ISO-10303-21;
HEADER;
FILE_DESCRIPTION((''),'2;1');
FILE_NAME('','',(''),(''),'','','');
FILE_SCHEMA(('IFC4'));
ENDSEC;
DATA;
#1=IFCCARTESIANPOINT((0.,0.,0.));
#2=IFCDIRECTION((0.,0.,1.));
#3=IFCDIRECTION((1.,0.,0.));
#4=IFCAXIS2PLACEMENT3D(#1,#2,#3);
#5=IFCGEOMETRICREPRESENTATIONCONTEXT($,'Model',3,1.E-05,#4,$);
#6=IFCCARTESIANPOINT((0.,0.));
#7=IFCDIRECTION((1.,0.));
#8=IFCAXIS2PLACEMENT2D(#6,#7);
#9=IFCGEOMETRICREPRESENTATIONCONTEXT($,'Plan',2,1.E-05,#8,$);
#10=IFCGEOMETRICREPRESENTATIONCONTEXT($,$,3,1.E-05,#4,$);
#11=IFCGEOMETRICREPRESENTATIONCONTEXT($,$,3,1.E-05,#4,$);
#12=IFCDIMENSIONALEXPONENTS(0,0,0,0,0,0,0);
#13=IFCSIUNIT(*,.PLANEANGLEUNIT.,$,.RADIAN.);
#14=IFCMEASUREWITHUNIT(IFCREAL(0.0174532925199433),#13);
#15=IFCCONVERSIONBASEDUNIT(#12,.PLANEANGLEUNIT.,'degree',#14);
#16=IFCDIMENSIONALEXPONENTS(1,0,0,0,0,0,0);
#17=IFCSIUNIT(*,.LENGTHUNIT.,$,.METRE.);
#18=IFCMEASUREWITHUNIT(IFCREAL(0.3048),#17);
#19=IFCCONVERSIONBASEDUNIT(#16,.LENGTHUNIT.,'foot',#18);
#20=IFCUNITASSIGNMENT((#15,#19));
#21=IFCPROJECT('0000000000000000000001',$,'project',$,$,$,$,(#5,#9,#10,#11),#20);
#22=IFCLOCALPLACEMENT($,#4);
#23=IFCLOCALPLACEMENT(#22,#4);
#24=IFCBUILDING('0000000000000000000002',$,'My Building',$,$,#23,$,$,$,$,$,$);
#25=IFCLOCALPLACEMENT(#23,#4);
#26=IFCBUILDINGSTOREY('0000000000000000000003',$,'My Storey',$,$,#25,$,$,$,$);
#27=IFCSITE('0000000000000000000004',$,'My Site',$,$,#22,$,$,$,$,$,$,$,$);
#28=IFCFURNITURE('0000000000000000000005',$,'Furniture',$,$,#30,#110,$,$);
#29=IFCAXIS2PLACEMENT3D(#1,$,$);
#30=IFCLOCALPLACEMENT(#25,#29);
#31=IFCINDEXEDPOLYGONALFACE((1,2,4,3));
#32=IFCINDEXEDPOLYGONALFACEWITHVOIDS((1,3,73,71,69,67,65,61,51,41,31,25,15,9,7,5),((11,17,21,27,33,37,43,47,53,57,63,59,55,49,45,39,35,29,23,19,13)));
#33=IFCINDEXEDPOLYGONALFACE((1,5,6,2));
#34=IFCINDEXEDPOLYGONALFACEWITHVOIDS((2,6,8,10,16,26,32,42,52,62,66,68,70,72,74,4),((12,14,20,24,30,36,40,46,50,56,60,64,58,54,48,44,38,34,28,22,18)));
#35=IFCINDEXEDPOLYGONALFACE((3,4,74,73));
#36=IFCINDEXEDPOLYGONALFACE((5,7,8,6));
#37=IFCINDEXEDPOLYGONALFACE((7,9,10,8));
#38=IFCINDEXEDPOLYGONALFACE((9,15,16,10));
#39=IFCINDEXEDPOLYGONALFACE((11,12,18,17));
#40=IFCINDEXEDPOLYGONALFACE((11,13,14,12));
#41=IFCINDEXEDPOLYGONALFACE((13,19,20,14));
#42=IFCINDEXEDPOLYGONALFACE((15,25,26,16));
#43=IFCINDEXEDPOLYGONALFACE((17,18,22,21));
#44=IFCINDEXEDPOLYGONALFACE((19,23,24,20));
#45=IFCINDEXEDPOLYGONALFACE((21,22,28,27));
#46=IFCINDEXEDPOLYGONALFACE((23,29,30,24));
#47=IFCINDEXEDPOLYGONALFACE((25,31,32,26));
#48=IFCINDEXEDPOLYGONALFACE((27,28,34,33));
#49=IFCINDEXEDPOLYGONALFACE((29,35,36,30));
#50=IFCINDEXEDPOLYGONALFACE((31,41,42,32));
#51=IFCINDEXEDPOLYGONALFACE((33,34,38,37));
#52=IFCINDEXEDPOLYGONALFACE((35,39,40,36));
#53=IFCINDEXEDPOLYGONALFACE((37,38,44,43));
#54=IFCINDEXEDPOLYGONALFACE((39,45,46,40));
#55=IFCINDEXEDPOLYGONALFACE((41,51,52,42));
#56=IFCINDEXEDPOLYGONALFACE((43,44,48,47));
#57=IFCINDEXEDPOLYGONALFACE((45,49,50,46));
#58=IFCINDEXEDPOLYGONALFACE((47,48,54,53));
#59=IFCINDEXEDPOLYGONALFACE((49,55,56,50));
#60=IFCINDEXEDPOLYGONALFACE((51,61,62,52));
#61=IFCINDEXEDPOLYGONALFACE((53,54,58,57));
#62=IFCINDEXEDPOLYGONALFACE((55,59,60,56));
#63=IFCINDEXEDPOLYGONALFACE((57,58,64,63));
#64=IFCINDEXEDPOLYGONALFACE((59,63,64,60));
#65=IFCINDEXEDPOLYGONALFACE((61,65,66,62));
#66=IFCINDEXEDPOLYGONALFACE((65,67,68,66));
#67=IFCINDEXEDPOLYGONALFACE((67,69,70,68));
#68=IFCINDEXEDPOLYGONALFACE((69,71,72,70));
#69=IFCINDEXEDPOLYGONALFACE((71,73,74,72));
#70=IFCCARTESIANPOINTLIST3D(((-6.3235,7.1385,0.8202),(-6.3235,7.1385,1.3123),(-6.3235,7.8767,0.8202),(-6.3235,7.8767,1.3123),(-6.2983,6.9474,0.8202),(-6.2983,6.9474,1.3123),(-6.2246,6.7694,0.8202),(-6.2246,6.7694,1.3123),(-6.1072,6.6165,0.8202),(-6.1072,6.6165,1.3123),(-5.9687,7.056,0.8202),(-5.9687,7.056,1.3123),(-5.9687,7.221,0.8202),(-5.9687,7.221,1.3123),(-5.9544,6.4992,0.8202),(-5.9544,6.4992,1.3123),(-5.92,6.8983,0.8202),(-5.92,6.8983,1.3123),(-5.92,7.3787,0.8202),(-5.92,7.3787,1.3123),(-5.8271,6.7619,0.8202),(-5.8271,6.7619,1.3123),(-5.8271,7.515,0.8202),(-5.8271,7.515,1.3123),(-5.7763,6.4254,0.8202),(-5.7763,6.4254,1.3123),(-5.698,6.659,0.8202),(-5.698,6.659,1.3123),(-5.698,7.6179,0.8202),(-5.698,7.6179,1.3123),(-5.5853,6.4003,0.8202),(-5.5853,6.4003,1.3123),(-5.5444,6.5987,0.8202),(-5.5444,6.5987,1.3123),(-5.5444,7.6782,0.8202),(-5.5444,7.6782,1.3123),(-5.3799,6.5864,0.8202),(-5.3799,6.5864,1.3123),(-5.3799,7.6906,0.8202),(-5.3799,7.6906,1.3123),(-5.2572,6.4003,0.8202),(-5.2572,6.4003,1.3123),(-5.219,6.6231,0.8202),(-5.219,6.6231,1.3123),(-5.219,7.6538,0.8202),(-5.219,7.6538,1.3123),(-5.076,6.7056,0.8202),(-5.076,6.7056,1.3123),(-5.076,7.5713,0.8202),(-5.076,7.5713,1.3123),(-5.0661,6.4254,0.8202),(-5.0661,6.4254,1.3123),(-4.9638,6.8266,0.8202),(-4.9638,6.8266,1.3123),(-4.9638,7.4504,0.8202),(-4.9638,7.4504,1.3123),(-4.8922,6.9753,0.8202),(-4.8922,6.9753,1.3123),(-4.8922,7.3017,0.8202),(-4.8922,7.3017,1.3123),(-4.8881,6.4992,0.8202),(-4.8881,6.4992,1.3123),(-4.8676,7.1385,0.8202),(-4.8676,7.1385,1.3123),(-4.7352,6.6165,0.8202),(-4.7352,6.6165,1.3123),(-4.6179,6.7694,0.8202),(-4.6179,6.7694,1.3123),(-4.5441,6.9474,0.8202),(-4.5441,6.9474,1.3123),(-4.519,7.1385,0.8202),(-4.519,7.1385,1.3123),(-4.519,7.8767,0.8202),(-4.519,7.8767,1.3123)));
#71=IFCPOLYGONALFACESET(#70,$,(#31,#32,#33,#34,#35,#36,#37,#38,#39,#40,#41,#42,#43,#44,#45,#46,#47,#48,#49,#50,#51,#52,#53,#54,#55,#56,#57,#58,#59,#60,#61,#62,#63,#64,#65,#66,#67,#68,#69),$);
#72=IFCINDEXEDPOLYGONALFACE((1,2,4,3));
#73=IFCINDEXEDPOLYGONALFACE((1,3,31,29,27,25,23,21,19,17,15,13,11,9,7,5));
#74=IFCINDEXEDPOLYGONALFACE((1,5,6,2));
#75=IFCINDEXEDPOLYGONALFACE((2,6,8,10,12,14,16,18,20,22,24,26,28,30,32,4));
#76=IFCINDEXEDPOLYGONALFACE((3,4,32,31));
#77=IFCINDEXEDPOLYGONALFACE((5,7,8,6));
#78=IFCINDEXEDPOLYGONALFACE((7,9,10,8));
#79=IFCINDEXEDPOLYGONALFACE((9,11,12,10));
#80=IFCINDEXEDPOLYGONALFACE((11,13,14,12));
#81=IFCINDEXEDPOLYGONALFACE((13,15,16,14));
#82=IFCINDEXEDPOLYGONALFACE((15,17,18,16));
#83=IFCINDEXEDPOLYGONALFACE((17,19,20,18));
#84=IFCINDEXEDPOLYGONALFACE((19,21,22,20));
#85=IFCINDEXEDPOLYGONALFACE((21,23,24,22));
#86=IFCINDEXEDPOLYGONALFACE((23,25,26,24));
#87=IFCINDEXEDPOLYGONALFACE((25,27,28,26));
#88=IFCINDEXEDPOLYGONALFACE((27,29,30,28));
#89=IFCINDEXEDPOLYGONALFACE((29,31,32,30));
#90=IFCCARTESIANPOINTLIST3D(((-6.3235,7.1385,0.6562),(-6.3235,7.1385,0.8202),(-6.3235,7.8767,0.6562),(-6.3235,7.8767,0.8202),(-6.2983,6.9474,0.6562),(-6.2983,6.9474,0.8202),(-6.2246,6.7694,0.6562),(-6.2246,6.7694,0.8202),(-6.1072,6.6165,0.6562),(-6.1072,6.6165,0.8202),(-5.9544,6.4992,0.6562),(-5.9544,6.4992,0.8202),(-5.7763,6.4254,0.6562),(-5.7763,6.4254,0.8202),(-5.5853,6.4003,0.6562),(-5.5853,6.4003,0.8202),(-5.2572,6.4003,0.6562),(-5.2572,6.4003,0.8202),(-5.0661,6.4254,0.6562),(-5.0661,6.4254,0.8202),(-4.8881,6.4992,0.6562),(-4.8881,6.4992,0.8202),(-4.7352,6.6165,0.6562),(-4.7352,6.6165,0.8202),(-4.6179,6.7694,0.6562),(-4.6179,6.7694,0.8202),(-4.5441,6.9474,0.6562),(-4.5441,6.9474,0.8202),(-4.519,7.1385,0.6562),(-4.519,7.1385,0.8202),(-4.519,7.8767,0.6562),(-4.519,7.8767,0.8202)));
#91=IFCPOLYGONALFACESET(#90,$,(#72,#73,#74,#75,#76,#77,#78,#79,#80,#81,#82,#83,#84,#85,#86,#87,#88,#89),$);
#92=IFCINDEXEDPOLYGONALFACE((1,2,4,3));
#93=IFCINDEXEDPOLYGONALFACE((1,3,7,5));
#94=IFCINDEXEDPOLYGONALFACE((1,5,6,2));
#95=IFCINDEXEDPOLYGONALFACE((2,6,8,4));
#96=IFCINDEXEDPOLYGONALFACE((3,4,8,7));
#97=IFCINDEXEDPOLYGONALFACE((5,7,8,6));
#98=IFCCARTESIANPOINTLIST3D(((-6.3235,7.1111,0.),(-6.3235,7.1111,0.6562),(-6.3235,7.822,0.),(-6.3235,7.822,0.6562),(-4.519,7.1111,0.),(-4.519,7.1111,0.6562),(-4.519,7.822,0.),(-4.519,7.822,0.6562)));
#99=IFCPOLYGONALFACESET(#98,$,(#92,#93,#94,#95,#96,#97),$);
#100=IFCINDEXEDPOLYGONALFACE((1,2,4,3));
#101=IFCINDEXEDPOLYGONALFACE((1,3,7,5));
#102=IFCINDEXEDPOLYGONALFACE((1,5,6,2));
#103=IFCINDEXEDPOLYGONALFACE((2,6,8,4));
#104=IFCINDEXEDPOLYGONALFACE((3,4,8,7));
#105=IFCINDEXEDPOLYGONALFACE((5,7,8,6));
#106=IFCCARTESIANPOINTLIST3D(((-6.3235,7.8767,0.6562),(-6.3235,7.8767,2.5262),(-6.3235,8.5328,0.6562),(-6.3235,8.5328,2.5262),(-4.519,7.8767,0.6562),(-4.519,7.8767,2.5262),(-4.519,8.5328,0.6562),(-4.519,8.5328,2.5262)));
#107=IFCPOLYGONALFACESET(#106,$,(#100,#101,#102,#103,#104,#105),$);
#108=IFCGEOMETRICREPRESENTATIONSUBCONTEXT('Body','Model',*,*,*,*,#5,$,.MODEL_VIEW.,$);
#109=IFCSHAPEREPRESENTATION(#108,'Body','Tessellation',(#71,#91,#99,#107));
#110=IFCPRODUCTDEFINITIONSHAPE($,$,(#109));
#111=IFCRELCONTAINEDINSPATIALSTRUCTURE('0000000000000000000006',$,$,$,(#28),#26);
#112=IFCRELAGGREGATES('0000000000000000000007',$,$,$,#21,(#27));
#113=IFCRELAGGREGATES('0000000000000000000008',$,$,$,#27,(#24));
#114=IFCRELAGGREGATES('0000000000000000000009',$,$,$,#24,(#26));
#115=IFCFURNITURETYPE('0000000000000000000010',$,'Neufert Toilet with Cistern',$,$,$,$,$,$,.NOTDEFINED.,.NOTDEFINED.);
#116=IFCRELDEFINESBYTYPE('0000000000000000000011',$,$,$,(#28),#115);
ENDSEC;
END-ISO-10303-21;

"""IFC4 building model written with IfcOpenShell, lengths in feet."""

from ifc_helpers import new_model, entity, si_unit, converted_unit, frame, frame_2d, origin_with_axes, origin_2d_with_axis, place, context, subcontext, project, spatial, line, arc, indexed_curve, circle_curve, outline, extrude, source, transform, mapped, type_object, type_shapes, element, save


model = new_model("IFC4")

# Units and contexts
model_context = context("Model", 3, precision=1e-05, world=origin_with_axes())
plan_context = context("Plan", 2, precision=1e-05, world=origin_2d_with_axis())
context_of_model_1 = context(None, 3, precision=1e-05, world=origin_with_axes())
context_of_model_2 = context(None, 3, precision=1e-05, world=origin_with_axes())
body_context = subcontext(model_context, "Body", "Model", "MODEL_VIEW")
ifc_project = project(units=[converted_unit("PLANEANGLEUNIT", "degree", entity("IfcReal", 0.0174532925199433), si_unit("PLANEANGLEUNIT", "RADIAN"), dimensions=[0, 0, 0, 0, 0, 0, 0]), converted_unit("LENGTHUNIT", "foot", entity("IfcReal", 0.3048), si_unit("LENGTHUNIT", "METRE"), dimensions=[1, 0, 0, 0, 0, 0, 0])], contexts=[model_context, plan_context, context_of_model_1, context_of_model_2])

# Site, building, storey
site_placement = place(None, origin_with_axes())
site = spatial("IfcSite", under=ifc_project, at=site_placement, Name="My Site")
building_placement = place(site_placement, origin_with_axes())
building = spatial("IfcBuilding", under=site, at=building_placement, Name="My Building")
storey_placement = place(building_placement, origin_with_axes())
storey = spatial("IfcBuildingStorey", under=building, at=storey_placement, Name="My Storey")

# Furniture
furniture_type = type_object("IfcFurnitureType", Name="Neufert Toilet with Cistern", AssemblyPlace="NOTDEFINED", PredefinedType="NOTDEFINED")
shared_shape_1 = source(origin_with_axes(), body_context, "Body", "SweptSolid", [
    extrude(outline(indexed_curve([(-0.9022, -0.6562), (0.9022, -0.6562), (0.9022, -1.3944), (0.686, -1.9163), (0.164, -2.1325), (-0.164, -2.1325), (-0.686, -1.9163), (-0.9022, -1.3944)], segments=[line(1, 2), line(2, 3), arc(3, 4, 5), line(5, 6), arc(6, 7, 8), line(1, 8)]), holes=[circle_curve(frame_2d((0.0, -1.3944)), 0.5536)]), frame((0.0, 0.0, 0.8202), z_axis=(0.0, 0.0, 1.0), x_axis=(1.0, 0.0, 0.0)), (0.0, 0.0, 1.0), 0.4921),
    extrude(outline(indexed_curve([(-0.9022, -0.6562), (0.9022, -0.6562), (0.9022, -1.3944), (0.686, -1.9163), (0.164, -2.1325), (-0.164, -2.1325), (-0.686, -1.9163), (-0.9022, -1.3944)], segments=[line(1, 2), line(2, 3), arc(3, 4, 5), line(5, 6), arc(6, 7, 8), line(1, 8)])), frame((0.0, 0.0, 0.6562), z_axis=(0.0, 0.0, 1.0), x_axis=(1.0, 0.0, 0.0)), (0.0, 0.0, 1.0), 0.164),
    extrude(outline(indexed_curve([(-0.9022, -0.7108), (0.9022, -0.7108), (0.9022, -1.4217), (-0.9022, -1.4217)], segments=[line(1, 2), line(2, 3), line(3, 4), line(4, 1)])), origin_with_axes(), (0.0, 0.0, 1.0), 0.6562),
    extrude(outline(indexed_curve([(-0.9022, 0.0), (0.9022, 0.0), (0.9022, -0.6562), (-0.9022, -0.6562)], segments=[line(1, 2), line(2, 3), line(3, 4), line(4, 1)])), frame((0.0, 0.0, 0.6562), z_axis=(0.0, 0.0, 1.0), x_axis=(1.0, 0.0, 0.0)), (0.0, 0.0, 1.0), 1.8701),
])
type_shapes(furniture_type, [shared_shape_1])
furniture_placement = place(storey_placement, frame((-5.4212, 8.5328, 0.0), z_axis=(0.0, 0.0, 1.0), x_axis=(1.0, 0.0, 0.0)))
element("IfcFurniture", 1, at=furniture_placement, inside=storey, type_object=furniture_type, Name="Furniture", context=body_context, shape_type="MappedRepresentation", body=[
    mapped(shared_shape_1, transform((0.0, 0.0, 0.0), x_axis=(1.0, 0.0, 0.0), y_axis=(0.0, 1.0, 0.0), z_axis=(0.0, 0.0, 1.0), scale=1.0)),
])

save(model, "model.ifc")
